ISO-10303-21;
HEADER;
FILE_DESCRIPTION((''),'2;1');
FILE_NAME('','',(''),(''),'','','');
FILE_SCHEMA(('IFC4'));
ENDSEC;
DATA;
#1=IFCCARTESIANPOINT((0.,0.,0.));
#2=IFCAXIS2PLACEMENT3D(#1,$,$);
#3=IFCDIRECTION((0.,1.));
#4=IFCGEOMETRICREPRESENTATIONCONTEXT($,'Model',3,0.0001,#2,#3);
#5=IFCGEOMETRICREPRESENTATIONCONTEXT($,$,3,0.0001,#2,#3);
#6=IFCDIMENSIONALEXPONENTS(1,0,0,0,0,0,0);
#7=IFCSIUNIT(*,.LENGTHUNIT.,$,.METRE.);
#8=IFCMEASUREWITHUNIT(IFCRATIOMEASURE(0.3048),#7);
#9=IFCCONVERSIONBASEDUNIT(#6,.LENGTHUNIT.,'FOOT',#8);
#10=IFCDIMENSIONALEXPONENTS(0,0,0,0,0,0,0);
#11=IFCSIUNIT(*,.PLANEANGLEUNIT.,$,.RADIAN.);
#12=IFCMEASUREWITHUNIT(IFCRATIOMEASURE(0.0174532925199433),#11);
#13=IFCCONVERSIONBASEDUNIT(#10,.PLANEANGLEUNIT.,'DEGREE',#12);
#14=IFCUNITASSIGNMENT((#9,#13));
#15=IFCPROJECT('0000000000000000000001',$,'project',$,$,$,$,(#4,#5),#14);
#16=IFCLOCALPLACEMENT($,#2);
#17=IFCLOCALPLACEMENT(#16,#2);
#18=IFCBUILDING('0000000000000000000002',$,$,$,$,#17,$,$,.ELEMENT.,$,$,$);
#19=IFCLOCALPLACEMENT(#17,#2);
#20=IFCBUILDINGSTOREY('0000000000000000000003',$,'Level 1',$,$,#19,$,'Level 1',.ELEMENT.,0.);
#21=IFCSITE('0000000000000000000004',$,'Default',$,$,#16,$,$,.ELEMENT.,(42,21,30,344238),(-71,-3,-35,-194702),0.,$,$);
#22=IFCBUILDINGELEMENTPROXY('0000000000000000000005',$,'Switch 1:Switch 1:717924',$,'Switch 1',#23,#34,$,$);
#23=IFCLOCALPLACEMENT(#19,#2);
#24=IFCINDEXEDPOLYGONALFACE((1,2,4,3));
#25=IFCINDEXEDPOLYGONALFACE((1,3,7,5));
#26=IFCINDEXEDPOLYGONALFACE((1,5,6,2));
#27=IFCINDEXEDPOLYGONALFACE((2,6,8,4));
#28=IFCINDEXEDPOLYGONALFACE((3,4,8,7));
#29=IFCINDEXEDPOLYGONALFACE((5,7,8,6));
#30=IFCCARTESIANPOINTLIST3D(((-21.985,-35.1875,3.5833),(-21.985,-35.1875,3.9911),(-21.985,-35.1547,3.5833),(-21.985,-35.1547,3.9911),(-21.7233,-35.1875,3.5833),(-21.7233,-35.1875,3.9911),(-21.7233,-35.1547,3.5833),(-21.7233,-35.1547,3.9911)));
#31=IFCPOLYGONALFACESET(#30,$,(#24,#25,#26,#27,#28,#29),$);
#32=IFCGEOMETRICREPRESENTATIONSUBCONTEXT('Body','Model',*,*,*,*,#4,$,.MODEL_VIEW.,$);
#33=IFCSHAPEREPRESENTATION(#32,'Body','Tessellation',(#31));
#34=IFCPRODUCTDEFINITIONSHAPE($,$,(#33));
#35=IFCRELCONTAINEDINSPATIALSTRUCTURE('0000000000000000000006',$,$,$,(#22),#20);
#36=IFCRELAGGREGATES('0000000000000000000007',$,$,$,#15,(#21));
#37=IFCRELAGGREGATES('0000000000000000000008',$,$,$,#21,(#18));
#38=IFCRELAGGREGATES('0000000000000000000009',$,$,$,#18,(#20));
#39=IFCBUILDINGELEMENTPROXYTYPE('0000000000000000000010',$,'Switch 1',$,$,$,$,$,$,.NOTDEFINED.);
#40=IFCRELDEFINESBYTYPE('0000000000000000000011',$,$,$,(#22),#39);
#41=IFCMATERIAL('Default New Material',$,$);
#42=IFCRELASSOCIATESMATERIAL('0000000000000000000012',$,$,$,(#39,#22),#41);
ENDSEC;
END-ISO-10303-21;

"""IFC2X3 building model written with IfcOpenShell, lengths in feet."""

from ifc_helpers import new_model, entity, si_unit, converted_unit, direction, frame, origin, origin_2d_with_axis, place, context, subcontext, project, spatial, rectangle, extrude, source, transform, mapped, material, type_object, type_shapes, element, save


model = new_model("IFC2X3")

# Units and contexts
model_context = context("Model", 3, precision=0.0001, world=origin(), true_north=direction((0.0, 1.0)))
context_of_model = context(None, 3, precision=0.0001, world=origin(), true_north=direction((0.0, 1.0)))
body_context = subcontext(model_context, "Body", "Model", "MODEL_VIEW")
ifc_project = project(units=[converted_unit("LENGTHUNIT", "FOOT", entity("IfcRatioMeasure", 0.3048), si_unit("LENGTHUNIT", "METRE"), dimensions=[1, 0, 0, 0, 0, 0, 0]), converted_unit("PLANEANGLEUNIT", "DEGREE", entity("IfcRatioMeasure", 0.0174532925199433), si_unit("PLANEANGLEUNIT", "RADIAN"), dimensions=[0, 0, 0, 0, 0, 0, 0])], contexts=[model_context, context_of_model])

# Site, building, storey
site_placement = place(None, origin())
site = spatial("IfcSite", under=ifc_project, at=site_placement, Name="Default", CompositionType="ELEMENT", RefLatitude=(42, 21, 30, 344238), RefLongitude=(-71, -3, -35, -194702), RefElevation=0.0)
building_placement = place(site_placement, origin())
building = spatial("IfcBuilding", under=site, at=building_placement, CompositionType="ELEMENT")
storey_placement = place(building_placement, origin())
storey = spatial("IfcBuildingStorey", under=building, at=storey_placement, Name="Level 1", LongName="Level 1", CompositionType="ELEMENT", Elevation=0.0)

# Shared definitions
ifc_material = material(Name="Default New Material")

# Building element proxy
building_element_proxy_type_1 = type_object("IfcBuildingElementProxyType", Name="Switch 1", PredefinedType="NOTDEFINED", material=ifc_material)
shared_shape_1 = source(origin(), body_context, "Body", "SweptSolid", [
    extrude(rectangle(XDim=0.0328, YDim=0.2617, at=origin_2d_with_axis()), frame((0.0, -0.0164, 0.0), z_axis=(0.0, 0.0, 1.0), x_axis=(0.0, 1.0, 0.0)), (0.0, 0.0, 1.0), 0.4078),
])
type_shapes(building_element_proxy_type_1, [shared_shape_1])
proxy_1_placement = place(storey_placement, frame((-21.8542, -35.1875, 3.5833), z_axis=(0.0, 0.0, 1.0), x_axis=(-1.0, 0.0, 0.0)))
element("IfcBuildingElementProxy", 1, at=proxy_1_placement, inside=storey, type_object=building_element_proxy_type_1, material=ifc_material, Name="Switch 1:Switch 1:717924", ObjectType="Switch 1", context=body_context, shape_type="MappedRepresentation", body=[
    mapped(shared_shape_1, transform((0.0, 0.0, 0.0), scale=1.0)),
])

save(model, "model.ifc")
